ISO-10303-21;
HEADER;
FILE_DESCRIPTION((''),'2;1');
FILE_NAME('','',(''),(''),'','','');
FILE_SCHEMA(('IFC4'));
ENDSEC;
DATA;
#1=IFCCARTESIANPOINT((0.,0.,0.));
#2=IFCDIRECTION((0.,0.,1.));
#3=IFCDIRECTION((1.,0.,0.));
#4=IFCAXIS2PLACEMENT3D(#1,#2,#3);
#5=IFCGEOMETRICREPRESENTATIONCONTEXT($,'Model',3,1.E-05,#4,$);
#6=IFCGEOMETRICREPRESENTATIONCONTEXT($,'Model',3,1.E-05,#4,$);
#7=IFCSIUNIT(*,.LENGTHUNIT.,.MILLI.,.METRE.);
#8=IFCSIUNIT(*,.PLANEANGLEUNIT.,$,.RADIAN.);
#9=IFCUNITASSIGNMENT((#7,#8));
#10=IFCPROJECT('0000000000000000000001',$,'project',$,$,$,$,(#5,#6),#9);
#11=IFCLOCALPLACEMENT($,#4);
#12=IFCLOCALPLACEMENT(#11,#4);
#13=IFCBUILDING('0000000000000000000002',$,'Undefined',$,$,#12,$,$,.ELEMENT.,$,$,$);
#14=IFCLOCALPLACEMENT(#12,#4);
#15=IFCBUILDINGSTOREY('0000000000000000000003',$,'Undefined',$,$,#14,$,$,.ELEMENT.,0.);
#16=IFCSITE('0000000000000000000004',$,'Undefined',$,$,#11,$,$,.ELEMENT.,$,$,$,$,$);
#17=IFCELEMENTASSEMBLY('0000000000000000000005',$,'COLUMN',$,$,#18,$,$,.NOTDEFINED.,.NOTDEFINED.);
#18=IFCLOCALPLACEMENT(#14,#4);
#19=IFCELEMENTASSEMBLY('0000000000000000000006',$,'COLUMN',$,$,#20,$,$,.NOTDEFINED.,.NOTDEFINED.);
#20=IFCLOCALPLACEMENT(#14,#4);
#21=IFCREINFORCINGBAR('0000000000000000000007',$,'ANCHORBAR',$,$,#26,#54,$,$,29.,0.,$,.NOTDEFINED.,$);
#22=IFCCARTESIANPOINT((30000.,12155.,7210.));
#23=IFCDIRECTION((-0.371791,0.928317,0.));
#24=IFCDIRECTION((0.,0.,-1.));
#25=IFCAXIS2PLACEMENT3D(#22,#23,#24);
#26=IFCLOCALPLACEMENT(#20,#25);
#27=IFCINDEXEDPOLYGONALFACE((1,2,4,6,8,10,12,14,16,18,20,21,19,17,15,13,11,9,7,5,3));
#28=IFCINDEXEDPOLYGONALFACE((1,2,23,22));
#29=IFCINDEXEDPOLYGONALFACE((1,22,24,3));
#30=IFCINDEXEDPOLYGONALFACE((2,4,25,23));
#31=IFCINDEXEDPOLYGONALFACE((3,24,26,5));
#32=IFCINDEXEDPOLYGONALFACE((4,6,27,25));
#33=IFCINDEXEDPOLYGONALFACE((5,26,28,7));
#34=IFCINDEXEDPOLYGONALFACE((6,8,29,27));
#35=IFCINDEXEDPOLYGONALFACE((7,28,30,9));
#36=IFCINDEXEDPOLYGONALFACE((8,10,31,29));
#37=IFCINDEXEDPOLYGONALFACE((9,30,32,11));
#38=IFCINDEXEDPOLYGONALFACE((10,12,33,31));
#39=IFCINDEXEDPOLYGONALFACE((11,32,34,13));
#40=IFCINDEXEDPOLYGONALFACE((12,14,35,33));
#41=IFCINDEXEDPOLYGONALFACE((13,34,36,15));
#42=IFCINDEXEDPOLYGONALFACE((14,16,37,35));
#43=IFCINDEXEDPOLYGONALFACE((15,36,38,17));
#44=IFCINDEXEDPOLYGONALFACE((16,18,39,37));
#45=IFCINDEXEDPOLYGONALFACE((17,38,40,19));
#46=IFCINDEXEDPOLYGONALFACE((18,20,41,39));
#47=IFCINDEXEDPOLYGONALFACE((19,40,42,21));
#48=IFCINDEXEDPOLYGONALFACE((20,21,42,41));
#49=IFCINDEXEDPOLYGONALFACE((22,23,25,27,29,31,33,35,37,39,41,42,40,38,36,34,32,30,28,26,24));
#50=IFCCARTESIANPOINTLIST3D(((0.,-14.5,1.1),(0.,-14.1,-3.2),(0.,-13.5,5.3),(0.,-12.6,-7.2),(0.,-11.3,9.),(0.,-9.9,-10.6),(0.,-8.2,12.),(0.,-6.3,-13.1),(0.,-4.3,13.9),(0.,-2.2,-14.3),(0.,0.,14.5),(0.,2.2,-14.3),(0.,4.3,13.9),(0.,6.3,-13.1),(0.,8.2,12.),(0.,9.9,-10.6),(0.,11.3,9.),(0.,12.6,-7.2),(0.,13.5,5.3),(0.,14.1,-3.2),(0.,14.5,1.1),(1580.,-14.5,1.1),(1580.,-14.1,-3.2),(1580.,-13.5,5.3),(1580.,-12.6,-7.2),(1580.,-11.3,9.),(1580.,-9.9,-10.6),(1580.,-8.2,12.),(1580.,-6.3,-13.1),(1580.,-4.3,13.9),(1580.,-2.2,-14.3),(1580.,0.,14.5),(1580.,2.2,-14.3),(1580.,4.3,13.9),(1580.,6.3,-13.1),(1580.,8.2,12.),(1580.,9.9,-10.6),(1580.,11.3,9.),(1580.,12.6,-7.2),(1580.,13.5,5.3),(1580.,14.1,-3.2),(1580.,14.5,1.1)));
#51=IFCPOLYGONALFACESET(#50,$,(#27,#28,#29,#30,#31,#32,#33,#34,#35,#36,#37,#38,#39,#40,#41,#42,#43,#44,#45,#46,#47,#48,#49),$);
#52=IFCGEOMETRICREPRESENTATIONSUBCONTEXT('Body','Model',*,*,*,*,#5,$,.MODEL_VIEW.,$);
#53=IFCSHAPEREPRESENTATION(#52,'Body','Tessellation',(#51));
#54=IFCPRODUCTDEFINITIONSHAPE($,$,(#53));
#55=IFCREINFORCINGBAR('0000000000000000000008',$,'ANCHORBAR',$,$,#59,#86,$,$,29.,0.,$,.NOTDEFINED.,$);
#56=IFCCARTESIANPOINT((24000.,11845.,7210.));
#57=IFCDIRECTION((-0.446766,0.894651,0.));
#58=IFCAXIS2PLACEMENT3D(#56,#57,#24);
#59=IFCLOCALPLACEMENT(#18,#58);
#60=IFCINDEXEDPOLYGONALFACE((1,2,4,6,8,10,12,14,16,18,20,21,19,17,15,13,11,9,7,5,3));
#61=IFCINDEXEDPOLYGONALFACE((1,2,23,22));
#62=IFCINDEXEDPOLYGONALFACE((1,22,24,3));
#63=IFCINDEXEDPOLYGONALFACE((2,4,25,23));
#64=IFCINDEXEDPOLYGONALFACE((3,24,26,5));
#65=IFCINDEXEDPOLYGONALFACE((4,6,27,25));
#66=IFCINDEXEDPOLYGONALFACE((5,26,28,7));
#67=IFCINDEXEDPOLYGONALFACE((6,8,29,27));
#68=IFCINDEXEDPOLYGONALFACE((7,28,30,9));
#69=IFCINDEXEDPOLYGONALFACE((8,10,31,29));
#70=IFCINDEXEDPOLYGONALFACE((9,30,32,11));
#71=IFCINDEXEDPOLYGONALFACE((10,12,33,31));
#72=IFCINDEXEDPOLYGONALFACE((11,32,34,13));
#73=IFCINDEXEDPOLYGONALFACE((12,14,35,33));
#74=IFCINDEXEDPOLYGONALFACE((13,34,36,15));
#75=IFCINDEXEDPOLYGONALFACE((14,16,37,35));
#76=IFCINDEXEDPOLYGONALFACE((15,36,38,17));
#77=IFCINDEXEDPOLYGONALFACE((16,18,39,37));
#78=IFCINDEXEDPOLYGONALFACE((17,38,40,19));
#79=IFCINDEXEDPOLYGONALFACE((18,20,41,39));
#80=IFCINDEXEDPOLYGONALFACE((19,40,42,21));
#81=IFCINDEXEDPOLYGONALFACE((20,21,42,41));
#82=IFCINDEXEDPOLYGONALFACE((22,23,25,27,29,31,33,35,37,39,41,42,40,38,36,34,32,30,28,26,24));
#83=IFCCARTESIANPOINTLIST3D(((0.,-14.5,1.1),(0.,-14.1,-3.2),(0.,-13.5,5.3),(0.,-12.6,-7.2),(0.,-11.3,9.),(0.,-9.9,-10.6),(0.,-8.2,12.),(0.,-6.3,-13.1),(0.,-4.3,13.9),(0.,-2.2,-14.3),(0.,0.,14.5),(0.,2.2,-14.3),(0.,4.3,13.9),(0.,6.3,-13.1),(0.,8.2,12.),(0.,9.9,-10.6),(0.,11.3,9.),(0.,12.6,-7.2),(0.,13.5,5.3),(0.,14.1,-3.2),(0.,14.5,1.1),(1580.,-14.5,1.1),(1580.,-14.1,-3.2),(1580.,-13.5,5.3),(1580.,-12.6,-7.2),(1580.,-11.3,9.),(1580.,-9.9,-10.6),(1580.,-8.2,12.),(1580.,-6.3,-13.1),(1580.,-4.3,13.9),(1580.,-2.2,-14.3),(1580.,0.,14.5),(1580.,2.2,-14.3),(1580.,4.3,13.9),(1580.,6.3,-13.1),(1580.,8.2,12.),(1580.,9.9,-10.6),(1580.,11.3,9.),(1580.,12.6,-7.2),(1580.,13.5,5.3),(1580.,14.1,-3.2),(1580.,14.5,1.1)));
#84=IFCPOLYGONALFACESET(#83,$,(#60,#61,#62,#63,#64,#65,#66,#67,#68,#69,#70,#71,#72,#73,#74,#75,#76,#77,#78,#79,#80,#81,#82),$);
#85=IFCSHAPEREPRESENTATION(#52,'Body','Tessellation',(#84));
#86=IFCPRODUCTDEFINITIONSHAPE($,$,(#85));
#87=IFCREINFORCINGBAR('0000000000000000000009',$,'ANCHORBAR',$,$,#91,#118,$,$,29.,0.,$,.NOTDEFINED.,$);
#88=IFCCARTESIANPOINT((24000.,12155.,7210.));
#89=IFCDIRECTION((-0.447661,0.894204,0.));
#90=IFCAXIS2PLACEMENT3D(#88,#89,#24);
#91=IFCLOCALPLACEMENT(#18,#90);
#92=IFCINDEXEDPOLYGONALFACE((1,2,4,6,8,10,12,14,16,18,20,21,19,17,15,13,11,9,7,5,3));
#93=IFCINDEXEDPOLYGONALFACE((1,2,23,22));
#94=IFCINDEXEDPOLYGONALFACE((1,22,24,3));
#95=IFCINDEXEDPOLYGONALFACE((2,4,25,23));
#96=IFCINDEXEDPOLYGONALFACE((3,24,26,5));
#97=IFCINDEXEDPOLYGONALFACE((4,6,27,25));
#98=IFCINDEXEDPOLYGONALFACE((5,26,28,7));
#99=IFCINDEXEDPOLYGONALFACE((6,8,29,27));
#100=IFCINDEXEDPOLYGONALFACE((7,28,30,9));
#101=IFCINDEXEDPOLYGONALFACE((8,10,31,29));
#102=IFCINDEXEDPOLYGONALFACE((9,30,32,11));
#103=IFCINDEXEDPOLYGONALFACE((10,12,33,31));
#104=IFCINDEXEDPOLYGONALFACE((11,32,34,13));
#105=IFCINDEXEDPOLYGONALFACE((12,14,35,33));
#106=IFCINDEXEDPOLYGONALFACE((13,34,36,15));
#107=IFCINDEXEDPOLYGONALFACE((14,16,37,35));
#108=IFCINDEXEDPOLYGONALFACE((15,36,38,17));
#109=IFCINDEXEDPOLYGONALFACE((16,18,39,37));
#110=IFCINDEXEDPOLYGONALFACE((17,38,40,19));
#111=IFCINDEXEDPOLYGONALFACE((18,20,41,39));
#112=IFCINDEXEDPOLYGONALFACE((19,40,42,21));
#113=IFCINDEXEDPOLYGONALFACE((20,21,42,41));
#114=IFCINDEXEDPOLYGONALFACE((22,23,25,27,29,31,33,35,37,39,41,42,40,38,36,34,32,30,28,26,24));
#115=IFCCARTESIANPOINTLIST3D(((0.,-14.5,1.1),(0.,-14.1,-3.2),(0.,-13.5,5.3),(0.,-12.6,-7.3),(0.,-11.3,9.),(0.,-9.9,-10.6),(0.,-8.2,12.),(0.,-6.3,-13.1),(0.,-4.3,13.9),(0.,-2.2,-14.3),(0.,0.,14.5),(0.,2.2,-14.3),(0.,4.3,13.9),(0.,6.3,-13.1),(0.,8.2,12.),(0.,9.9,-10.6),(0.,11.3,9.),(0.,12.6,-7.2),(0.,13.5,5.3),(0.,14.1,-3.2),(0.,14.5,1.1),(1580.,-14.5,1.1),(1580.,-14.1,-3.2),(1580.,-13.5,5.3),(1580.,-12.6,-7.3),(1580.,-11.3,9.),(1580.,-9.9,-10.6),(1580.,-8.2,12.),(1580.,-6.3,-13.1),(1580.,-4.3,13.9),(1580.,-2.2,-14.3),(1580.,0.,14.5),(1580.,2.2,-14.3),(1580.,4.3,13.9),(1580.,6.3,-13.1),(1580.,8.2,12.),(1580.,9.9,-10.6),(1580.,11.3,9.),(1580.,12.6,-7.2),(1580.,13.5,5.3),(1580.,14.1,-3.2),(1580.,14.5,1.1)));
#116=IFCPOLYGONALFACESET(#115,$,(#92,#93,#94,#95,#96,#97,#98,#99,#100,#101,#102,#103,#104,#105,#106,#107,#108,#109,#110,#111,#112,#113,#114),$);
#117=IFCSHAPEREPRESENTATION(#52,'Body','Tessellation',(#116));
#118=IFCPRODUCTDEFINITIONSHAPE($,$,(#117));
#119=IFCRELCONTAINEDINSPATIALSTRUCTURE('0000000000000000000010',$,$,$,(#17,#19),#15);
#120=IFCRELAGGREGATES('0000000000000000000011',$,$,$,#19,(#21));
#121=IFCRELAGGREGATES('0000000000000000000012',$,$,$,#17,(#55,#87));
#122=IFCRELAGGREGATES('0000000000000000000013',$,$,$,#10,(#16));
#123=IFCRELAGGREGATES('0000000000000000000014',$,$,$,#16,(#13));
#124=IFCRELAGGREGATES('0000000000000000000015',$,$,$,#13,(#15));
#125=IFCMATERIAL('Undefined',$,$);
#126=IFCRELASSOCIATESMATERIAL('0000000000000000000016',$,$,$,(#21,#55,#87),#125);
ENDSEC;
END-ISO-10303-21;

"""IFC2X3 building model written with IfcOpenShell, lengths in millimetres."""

from ifc_helpers import new_model, entity, si_unit, frame, origin_with_axes, place, context, subcontext, project, spatial, source, transform, mapped, material, element, aggregate, save


model = new_model("IFC2X3")

# Units and contexts
model_context_1 = context("Model", 3, precision=1e-05, world=origin_with_axes())
model_context_2 = context("Model", 3, precision=1e-05, world=origin_with_axes())
body_context = subcontext(model_context_1, "Body", "Model", "MODEL_VIEW")
ifc_project = project(units=[si_unit("LENGTHUNIT", "METRE", prefix="MILLI"), si_unit("PLANEANGLEUNIT", "RADIAN")], contexts=[model_context_1, model_context_2])

# Site, building, storey
site_placement = place(None, origin_with_axes())
site = spatial("IfcSite", under=ifc_project, at=site_placement, Name="Undefined", CompositionType="ELEMENT")
building_placement = place(site_placement, origin_with_axes())
building = spatial("IfcBuilding", under=site, at=building_placement, Name="Undefined", CompositionType="ELEMENT")
storey_placement = place(building_placement, origin_with_axes())
storey = spatial("IfcBuildingStorey", under=building, at=storey_placement, Name="Undefined", CompositionType="ELEMENT", Elevation=0.0)

# Element assemblies
assembly_1_placement = place(storey_placement, origin_with_axes())
assembly_1 = element("IfcElementAssembly", 1, at=assembly_1_placement, inside=storey, Name="COLUMN", AssemblyPlace="NOTDEFINED", PredefinedType="NOTDEFINED")
assembly_2_placement = place(storey_placement, origin_with_axes())
assembly_2 = element("IfcElementAssembly", 2, at=assembly_2_placement, inside=storey, Name="COLUMN", AssemblyPlace="NOTDEFINED", PredefinedType="NOTDEFINED")

# Shared definitions
ifc_material_1 = material(Name="Undefined")

# Reinforcing bars
shared_shape_1 = source(origin_with_axes(), body_context, "Body", "AdvancedSweptSolid", [
    entity("IfcSweptDiskSolid", entity("IfcTrimmedCurve", entity("IfcLine", entity("IfcCartesianPoint", [0.0, 0.0, 0.0]), entity("IfcVector", entity("IfcDirection", [1.0, 0.0, 0.0]), 1.0)), [entity("IfcParameterValue", 0.0)], [entity("IfcParameterValue", 1580.0)], True, "PARAMETER"), 14.5, None, 0.0, 1580.0),
])
reinforcing_bar_1_placement = place(assembly_2_placement, frame((30000.0, 12155.0, 7210.0), z_axis=(-0.371791, 0.928317, 0.0), x_axis=(0.0, 0.0, -1.0)))
reinforcing_bar_1 = element("IfcReinforcingBar", 3, at=reinforcing_bar_1_placement, material=ifc_material_1, Name="ANCHORBAR", BarRole="NOTDEFINED", CrossSectionArea=0.0, NominalDiameter=29.0, context=body_context, shape_type="MappedRepresentation", body=[
    mapped(shared_shape_1, transform((0.0, 0.0, 0.0))),
])
aggregate(assembly_2, [reinforcing_bar_1])
shared_shape_2 = source(origin_with_axes(), body_context, "Body", "AdvancedSweptSolid", [
    entity("IfcSweptDiskSolid", entity("IfcTrimmedCurve", entity("IfcLine", entity("IfcCartesianPoint", [0.0, 0.0, 0.0]), entity("IfcVector", entity("IfcDirection", [1.0, 0.0, 0.0]), 1.0)), [entity("IfcParameterValue", 0.0)], [entity("IfcParameterValue", 1580.0)], True, "PARAMETER"), 14.5, None, 0.0, 1580.0),
])
reinforcing_bar_2_placement = place(assembly_1_placement, frame((24000.0, 11845.0, 7210.0), z_axis=(-0.446766, 0.894651, 0.0), x_axis=(0.0, 0.0, -1.0)))
reinforcing_bar_2 = element("IfcReinforcingBar", 4, at=reinforcing_bar_2_placement, material=ifc_material_1, Name="ANCHORBAR", BarRole="NOTDEFINED", CrossSectionArea=0.0, NominalDiameter=29.0, context=body_context, shape_type="MappedRepresentation", body=[
    mapped(shared_shape_2, transform((0.0, 0.0, 0.0))),
])
shared_shape_3 = source(origin_with_axes(), body_context, "Body", "AdvancedSweptSolid", [
    entity("IfcSweptDiskSolid", entity("IfcTrimmedCurve", entity("IfcLine", entity("IfcCartesianPoint", [0.0, 0.0, 0.0]), entity("IfcVector", entity("IfcDirection", [1.0, 0.0, 0.0]), 1.0)), [entity("IfcParameterValue", 0.0)], [entity("IfcParameterValue", 1580.0)], True, "PARAMETER"), 14.5, None, 0.0, 1580.0),
])
reinforcing_bar_3_placement = place(assembly_1_placement, frame((24000.0, 12155.0, 7210.0), z_axis=(-0.447661, 0.894204, 0.0), x_axis=(0.0, 0.0, -1.0)))
reinforcing_bar_3 = element("IfcReinforcingBar", 5, at=reinforcing_bar_3_placement, material=ifc_material_1, Name="ANCHORBAR", BarRole="NOTDEFINED", CrossSectionArea=0.0, NominalDiameter=29.0, context=body_context, shape_type="MappedRepresentation", body=[
    mapped(shared_shape_3, transform((0.0, 0.0, 0.0))),
])
aggregate(assembly_1, [reinforcing_bar_2, reinforcing_bar_3])

save(model, "model.ifc")
